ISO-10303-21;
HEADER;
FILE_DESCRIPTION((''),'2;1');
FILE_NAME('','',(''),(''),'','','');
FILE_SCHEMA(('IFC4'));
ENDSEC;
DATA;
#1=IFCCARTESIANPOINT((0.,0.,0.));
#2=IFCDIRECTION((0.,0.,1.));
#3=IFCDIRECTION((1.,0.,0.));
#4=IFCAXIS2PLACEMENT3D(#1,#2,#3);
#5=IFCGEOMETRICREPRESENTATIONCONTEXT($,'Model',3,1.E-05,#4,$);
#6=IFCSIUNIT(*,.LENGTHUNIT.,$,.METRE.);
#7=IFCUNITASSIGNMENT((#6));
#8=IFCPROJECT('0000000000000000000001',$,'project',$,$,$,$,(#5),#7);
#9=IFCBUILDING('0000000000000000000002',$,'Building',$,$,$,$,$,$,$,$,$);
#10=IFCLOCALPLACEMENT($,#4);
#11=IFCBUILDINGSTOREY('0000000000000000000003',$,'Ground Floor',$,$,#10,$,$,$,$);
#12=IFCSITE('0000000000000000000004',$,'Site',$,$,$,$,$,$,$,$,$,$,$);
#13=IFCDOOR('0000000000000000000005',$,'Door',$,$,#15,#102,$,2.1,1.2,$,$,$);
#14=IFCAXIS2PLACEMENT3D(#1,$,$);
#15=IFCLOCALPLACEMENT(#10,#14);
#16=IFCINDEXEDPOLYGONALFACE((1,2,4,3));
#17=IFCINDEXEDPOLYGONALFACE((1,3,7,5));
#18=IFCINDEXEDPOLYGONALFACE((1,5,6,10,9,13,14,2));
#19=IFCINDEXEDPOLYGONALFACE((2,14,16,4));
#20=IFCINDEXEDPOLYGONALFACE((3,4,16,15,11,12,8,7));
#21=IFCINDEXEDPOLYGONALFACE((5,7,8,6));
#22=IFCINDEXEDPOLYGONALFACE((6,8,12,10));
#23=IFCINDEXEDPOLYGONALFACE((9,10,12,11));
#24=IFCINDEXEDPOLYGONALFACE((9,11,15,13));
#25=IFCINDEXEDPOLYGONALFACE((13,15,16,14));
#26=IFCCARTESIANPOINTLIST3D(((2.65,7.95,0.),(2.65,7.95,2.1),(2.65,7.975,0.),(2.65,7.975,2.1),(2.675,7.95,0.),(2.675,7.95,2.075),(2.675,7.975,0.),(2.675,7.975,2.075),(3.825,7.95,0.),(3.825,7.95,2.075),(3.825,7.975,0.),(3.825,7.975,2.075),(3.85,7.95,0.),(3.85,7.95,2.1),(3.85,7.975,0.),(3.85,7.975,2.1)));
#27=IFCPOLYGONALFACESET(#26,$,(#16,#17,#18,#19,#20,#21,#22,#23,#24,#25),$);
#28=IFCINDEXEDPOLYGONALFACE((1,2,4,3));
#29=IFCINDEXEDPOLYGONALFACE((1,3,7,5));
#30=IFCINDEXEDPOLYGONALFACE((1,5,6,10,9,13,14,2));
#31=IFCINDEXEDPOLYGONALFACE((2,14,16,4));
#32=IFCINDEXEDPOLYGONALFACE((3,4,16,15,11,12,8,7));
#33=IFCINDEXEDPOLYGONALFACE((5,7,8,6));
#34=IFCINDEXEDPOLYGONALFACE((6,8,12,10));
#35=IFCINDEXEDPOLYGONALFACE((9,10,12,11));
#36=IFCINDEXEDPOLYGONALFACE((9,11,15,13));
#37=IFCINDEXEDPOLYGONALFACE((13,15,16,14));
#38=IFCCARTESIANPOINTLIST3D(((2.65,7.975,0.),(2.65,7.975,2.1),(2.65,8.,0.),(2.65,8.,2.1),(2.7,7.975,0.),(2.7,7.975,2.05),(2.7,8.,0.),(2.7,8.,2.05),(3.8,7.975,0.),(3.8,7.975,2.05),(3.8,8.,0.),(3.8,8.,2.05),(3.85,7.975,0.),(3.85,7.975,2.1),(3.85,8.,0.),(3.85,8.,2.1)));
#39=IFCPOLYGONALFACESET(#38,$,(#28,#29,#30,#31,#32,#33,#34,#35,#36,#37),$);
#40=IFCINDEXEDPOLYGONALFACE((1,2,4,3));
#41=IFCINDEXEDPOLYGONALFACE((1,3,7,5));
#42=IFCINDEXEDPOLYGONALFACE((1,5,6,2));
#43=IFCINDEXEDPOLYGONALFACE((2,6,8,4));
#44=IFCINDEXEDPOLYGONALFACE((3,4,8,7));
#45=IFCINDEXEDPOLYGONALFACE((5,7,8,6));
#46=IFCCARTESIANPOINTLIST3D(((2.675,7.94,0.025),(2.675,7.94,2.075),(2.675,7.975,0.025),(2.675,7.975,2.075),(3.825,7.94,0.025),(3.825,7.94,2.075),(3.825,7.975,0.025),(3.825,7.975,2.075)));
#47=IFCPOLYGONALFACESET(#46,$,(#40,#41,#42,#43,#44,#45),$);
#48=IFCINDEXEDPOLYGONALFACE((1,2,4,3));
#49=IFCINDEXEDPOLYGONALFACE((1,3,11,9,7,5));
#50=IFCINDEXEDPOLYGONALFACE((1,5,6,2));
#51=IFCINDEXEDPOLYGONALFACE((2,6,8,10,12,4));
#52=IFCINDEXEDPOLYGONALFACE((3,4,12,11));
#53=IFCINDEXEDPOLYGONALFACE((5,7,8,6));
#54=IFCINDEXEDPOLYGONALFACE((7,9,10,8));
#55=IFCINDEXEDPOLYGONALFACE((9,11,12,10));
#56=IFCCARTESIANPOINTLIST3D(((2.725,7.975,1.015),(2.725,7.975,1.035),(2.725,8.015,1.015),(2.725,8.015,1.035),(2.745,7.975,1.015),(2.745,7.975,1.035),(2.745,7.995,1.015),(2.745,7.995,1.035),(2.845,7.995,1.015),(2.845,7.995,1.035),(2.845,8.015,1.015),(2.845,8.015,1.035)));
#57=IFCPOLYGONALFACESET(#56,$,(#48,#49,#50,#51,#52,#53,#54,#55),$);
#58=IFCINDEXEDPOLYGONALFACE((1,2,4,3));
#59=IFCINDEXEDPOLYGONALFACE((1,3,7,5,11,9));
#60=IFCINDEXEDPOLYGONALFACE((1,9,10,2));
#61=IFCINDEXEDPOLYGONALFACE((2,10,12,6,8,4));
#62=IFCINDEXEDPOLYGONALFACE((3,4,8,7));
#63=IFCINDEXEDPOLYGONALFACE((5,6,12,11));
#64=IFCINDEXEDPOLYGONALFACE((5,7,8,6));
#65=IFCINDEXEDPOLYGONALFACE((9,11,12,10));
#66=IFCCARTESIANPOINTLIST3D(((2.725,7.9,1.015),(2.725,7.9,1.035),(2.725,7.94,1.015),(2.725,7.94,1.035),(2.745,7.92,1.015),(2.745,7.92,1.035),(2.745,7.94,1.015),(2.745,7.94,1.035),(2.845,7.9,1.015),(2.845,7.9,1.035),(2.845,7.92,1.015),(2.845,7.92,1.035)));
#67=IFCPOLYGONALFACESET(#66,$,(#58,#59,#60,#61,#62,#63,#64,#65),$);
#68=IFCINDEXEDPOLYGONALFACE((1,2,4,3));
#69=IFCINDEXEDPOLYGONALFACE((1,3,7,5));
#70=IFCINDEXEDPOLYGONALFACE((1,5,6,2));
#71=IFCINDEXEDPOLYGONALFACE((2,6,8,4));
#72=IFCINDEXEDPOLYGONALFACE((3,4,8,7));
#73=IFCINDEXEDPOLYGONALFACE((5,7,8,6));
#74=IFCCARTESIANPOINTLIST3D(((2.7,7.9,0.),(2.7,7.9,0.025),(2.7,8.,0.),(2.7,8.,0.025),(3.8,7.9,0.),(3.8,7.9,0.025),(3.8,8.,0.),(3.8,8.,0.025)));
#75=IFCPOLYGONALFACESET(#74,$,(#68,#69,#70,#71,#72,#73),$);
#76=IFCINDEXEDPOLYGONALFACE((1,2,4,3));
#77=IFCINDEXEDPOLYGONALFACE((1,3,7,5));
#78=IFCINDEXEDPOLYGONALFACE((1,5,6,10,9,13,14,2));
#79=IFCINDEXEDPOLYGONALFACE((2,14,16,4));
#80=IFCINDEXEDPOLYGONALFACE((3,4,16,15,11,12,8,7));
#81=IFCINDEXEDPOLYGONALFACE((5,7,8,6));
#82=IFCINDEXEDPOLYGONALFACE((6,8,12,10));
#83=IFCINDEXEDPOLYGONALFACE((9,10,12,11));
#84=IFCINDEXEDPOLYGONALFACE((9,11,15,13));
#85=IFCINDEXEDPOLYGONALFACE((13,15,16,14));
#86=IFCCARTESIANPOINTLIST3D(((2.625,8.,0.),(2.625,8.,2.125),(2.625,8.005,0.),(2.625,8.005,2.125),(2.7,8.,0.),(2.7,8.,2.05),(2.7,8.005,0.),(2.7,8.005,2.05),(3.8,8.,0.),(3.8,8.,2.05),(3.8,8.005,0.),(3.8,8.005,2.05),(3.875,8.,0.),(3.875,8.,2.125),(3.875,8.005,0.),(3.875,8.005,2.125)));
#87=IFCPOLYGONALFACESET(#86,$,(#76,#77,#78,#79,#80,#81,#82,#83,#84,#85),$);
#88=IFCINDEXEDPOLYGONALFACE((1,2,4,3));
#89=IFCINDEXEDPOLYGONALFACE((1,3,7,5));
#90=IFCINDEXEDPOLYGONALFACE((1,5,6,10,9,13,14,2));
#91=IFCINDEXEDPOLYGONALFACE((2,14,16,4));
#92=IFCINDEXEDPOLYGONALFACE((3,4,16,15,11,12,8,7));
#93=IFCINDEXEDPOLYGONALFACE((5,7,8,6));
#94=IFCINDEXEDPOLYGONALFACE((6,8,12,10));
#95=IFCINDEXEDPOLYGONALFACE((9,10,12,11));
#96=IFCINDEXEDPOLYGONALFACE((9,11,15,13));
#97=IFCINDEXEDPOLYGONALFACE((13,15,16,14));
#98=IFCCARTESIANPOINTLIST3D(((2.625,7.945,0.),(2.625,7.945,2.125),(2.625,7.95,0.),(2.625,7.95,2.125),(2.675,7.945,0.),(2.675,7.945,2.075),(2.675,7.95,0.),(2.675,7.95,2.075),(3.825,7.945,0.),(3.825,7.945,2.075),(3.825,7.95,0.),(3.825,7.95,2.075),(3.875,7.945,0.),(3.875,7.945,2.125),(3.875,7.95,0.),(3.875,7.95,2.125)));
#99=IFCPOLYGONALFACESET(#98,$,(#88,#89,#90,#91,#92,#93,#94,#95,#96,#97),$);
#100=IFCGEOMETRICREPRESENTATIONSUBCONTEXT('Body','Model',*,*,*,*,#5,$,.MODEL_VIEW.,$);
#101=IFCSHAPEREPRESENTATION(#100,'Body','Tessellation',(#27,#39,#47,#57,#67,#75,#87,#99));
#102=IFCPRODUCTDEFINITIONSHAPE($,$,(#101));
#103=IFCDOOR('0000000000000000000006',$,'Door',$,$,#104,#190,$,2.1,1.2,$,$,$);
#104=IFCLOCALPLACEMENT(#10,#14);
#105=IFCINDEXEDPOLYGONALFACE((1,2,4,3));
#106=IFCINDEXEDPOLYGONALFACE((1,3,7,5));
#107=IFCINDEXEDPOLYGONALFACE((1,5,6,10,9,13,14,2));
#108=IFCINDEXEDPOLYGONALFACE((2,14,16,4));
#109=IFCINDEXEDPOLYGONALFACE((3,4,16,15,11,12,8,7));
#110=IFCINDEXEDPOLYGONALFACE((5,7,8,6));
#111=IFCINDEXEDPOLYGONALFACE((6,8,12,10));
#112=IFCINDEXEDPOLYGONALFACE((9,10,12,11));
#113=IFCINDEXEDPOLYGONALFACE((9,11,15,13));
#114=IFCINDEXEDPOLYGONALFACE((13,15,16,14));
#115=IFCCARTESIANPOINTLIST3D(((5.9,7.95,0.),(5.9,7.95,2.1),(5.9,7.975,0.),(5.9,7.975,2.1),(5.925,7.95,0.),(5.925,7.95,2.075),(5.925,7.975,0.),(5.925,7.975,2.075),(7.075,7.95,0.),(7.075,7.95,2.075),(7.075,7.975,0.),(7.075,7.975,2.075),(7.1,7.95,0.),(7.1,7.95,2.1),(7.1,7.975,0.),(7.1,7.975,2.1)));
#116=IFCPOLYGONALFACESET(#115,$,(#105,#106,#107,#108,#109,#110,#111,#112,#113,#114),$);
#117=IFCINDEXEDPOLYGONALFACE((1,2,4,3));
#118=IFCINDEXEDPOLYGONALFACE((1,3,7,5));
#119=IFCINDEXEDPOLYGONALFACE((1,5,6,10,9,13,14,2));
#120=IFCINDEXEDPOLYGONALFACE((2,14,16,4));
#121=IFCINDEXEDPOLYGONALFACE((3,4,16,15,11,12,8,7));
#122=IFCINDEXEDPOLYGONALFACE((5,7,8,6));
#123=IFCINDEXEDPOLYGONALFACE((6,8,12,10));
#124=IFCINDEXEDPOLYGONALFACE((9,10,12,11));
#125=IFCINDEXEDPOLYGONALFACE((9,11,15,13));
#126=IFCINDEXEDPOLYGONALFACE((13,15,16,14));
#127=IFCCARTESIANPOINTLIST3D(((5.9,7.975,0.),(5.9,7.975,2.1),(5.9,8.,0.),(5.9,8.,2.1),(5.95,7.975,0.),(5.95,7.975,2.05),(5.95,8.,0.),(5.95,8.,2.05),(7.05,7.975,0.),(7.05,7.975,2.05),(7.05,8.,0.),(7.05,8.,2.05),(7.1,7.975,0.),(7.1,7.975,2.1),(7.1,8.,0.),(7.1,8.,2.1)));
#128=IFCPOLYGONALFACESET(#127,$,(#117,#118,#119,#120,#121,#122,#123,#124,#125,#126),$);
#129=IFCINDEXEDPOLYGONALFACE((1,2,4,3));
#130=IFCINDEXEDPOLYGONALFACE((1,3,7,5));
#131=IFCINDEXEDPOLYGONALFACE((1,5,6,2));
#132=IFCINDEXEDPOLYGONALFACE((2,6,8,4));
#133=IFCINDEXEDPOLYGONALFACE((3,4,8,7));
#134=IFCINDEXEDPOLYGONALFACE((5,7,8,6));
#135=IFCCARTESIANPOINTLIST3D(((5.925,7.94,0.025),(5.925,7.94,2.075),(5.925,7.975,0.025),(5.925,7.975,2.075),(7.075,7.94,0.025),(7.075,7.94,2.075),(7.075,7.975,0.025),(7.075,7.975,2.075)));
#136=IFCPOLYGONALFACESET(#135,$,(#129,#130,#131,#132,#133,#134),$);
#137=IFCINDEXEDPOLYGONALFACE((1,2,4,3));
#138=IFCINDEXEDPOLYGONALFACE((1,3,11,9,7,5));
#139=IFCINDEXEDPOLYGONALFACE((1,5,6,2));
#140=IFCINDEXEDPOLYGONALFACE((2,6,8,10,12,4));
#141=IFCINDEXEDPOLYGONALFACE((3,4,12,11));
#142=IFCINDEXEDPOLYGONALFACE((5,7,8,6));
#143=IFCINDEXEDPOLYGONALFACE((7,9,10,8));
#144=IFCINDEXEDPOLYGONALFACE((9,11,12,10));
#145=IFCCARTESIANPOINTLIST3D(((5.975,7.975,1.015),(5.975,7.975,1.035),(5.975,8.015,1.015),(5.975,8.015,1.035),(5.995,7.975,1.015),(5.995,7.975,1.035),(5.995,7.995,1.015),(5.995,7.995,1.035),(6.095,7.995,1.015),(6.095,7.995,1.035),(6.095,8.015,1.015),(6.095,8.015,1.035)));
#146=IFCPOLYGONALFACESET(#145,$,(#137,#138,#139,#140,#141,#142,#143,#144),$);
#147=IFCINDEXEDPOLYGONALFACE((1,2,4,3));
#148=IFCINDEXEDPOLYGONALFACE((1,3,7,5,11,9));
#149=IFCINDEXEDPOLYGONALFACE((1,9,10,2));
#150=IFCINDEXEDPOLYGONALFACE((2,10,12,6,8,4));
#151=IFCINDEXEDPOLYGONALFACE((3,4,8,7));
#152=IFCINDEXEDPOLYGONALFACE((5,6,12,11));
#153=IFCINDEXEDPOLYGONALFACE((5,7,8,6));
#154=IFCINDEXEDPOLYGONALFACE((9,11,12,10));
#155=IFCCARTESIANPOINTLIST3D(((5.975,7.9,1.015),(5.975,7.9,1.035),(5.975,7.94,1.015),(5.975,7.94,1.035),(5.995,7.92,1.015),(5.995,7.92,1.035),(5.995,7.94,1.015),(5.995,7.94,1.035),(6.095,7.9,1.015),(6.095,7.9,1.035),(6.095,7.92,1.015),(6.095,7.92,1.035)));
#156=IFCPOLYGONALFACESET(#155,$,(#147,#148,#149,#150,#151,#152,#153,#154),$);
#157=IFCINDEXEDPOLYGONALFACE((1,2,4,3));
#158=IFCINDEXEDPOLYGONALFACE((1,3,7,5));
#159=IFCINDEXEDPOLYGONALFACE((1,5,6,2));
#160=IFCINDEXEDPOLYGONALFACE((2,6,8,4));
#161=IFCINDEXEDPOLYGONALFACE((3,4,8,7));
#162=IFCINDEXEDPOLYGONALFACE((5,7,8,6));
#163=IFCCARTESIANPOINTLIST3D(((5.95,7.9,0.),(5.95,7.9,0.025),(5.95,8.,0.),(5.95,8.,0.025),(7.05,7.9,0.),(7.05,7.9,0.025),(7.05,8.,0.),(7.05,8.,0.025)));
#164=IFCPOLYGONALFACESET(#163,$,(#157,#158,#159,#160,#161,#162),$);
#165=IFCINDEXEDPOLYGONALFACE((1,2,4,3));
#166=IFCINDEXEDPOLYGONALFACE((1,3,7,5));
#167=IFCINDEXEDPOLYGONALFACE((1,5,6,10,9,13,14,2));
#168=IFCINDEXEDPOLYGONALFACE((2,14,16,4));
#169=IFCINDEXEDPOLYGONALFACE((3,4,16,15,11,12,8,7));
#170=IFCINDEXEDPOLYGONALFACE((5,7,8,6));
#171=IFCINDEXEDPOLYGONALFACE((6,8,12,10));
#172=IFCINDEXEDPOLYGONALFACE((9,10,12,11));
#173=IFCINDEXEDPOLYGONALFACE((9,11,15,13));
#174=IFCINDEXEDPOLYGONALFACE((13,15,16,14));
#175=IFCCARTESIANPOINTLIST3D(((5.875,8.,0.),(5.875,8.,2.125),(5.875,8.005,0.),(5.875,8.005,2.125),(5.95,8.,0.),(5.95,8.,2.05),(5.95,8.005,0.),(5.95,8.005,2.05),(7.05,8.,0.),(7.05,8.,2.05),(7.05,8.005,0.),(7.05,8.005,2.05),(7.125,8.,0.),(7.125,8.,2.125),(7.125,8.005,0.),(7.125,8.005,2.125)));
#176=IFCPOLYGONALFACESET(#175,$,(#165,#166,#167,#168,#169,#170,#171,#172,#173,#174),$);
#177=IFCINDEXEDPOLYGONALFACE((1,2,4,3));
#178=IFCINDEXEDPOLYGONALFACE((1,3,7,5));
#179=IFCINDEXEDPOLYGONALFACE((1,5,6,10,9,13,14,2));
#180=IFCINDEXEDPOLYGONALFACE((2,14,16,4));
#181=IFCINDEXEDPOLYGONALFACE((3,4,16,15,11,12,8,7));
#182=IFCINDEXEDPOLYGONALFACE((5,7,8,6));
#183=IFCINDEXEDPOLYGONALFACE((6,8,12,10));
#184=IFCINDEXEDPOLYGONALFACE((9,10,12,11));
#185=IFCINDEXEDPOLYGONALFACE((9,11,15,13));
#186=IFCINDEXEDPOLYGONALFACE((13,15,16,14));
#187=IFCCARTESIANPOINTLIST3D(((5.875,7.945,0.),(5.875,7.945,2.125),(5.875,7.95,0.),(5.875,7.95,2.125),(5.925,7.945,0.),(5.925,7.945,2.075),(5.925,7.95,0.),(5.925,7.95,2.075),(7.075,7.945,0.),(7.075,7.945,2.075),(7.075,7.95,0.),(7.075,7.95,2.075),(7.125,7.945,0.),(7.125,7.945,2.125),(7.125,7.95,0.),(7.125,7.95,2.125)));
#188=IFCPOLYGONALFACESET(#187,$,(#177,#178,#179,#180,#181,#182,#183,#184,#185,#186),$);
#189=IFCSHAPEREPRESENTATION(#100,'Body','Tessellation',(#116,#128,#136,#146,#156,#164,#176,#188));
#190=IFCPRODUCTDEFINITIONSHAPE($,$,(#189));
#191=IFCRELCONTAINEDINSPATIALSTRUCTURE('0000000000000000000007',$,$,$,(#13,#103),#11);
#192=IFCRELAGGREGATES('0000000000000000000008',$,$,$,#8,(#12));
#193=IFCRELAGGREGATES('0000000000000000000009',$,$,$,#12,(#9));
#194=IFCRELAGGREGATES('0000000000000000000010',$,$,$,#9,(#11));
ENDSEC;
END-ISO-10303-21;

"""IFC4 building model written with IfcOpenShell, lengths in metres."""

from ifc_helpers import new_model, si_unit, frame, origin_with_axes, place, context, subcontext, project, spatial, line, indexed_curve, outline, extrude, element, save


model = new_model("IFC4")

# Units and contexts
model_context = context("Model", 3, precision=1e-05, world=origin_with_axes())
body_context = subcontext(model_context, "Body", "Model", "MODEL_VIEW")
ifc_project = project(units=[si_unit("LENGTHUNIT", "METRE")], contexts=[model_context])

# Site, building, storey
site = spatial("IfcSite", under=ifc_project, Name="Site")
building = spatial("IfcBuilding", under=site, Name="Building")
storey_placement = place(None, origin_with_axes())
storey = spatial("IfcBuildingStorey", under=building, at=storey_placement, Name="Ground Floor")

# Doors
door_1_placement = place(storey_placement, frame((3.85, 8.0, 0.0), z_axis=(0.0, 0.0, 1.0), x_axis=(-1.0, 0.0, 0.0)))
element("IfcDoor", 1, at=door_1_placement, inside=storey, Name="Door", OverallHeight=2.1, OverallWidth=1.2, context=body_context, shape_type="SweptSolid", body=[
    extrude(outline(indexed_curve([(0.0, 0.0), (0.0, 2.1), (1.2, 2.1), (1.2, 0.0), (1.175, 0.0), (1.175, 2.075), (0.025, 2.075), (0.025, 0.0)], segments=[line(1, 2, 3, 4, 5, 6, 7, 8, 1)])), frame((0.0, 0.025, 0.0), z_axis=(0.0, -1.0, 0.0), x_axis=(1.0, 0.0, 0.0)), (0.0, 0.0, -1.0), 0.025),
    extrude(outline(indexed_curve([(0.0, 0.0), (0.0, 2.1), (1.2, 2.1), (1.2, 0.0), (1.15, 0.0), (1.15, 2.05), (0.05, 2.05), (0.05, 0.0)], segments=[line(1, 2, 3, 4, 5, 6, 7, 8, 1)])), frame((0.0, 0.0, 0.0), z_axis=(0.0, -1.0, 0.0), x_axis=(1.0, 0.0, 0.0)), (0.0, 0.0, -1.0), 0.025),
    extrude(outline(indexed_curve([(0.0, 0.0), (1.15, 0.0), (1.15, 0.035), (0.0, 0.035)], segments=[line(1, 2, 3, 4, 1)])), frame((0.025, 0.025, 0.025), z_axis=(0.0, 0.0, 1.0), x_axis=(1.0, 0.0, 0.0)), (0.0, 0.0, 1.0), 2.05),
    extrude(outline(indexed_curve([(0.0, 0.0), (0.0, -0.04), (-0.12, -0.04), (-0.12, -0.02), (-0.02, -0.02), (-0.02, 0.0)], segments=[line(1, 2, 3, 4, 5, 6, 1)])), frame((1.125, 0.025, 1.015), z_axis=(0.0, 0.0, 1.0), x_axis=(1.0, 0.0, 0.0)), (0.0, 0.0, 1.0), 0.02),
    extrude(outline(indexed_curve([(0.0, 0.0), (0.0, 0.04), (-0.12, 0.04), (-0.12, 0.02), (-0.02, 0.02), (-0.02, 0.0)], segments=[line(1, 2, 3, 4, 5, 6, 1)])), frame((1.125, 0.06, 1.015), z_axis=(0.0, 0.0, 1.0), x_axis=(1.0, 0.0, 0.0)), (0.0, 0.0, 1.0), 0.02),
    extrude(outline(indexed_curve([(0.0, 0.0), (1.1, 0.0), (1.1, 0.1), (0.0, 0.1)], segments=[line(1, 2, 3, 4, 1)])), frame((0.05, 0.0, 0.0), z_axis=(0.0, 0.0, 1.0), x_axis=(1.0, 0.0, 0.0)), (0.0, 0.0, 1.0), 0.025),
    extrude(outline(indexed_curve([(0.0, 0.0), (0.0, 2.125), (1.25, 2.125), (1.25, 0.0), (1.175, 0.0), (1.175, 2.05), (0.075, 2.05), (0.075, 0.0)], segments=[line(1, 2, 3, 4, 5, 6, 7, 8, 1)])), frame((-0.025, -0.005, 0.0), z_axis=(0.0, -1.0, 0.0), x_axis=(1.0, 0.0, 0.0)), (0.0, 0.0, -1.0), 0.005),
    extrude(outline(indexed_curve([(0.0, 0.0), (0.0, 2.125), (1.25, 2.125), (1.25, 0.0), (1.2, 0.0), (1.2, 2.075), (0.05, 2.075), (0.05, 0.0)], segments=[line(1, 2, 3, 4, 5, 6, 7, 8, 1)])), frame((-0.025, 0.05, 0.0), z_axis=(0.0, -1.0, 0.0), x_axis=(1.0, 0.0, 0.0)), (0.0, 0.0, -1.0), 0.005),
])
door_2_placement = place(storey_placement, frame((7.1, 8.0, 0.0), z_axis=(0.0, 0.0, 1.0), x_axis=(-1.0, 0.0, 0.0)))
element("IfcDoor", 2, at=door_2_placement, inside=storey, Name="Door", OverallHeight=2.1, OverallWidth=1.2, context=body_context, shape_type="SweptSolid", body=[
    extrude(outline(indexed_curve([(0.0, 0.0), (0.0, 2.1), (1.2, 2.1), (1.2, 0.0), (1.175, 0.0), (1.175, 2.075), (0.025, 2.075), (0.025, 0.0)], segments=[line(1, 2, 3, 4, 5, 6, 7, 8, 1)])), frame((0.0, 0.025, 0.0), z_axis=(0.0, -1.0, 0.0), x_axis=(1.0, 0.0, 0.0)), (0.0, 0.0, -1.0), 0.025),
    extrude(outline(indexed_curve([(0.0, 0.0), (0.0, 2.1), (1.2, 2.1), (1.2, 0.0), (1.15, 0.0), (1.15, 2.05), (0.05, 2.05), (0.05, 0.0)], segments=[line(1, 2, 3, 4, 5, 6, 7, 8, 1)])), frame((0.0, 0.0, 0.0), z_axis=(0.0, -1.0, 0.0), x_axis=(1.0, 0.0, 0.0)), (0.0, 0.0, -1.0), 0.025),
    extrude(outline(indexed_curve([(0.0, 0.0), (1.15, 0.0), (1.15, 0.035), (0.0, 0.035)], segments=[line(1, 2, 3, 4, 1)])), frame((0.025, 0.025, 0.025), z_axis=(0.0, 0.0, 1.0), x_axis=(1.0, 0.0, 0.0)), (0.0, 0.0, 1.0), 2.05),
    extrude(outline(indexed_curve([(0.0, 0.0), (0.0, -0.04), (-0.12, -0.04), (-0.12, -0.02), (-0.02, -0.02), (-0.02, 0.0)], segments=[line(1, 2, 3, 4, 5, 6, 1)])), frame((1.125, 0.025, 1.015), z_axis=(0.0, 0.0, 1.0), x_axis=(1.0, 0.0, 0.0)), (0.0, 0.0, 1.0), 0.02),
    extrude(outline(indexed_curve([(0.0, 0.0), (0.0, 0.04), (-0.12, 0.04), (-0.12, 0.02), (-0.02, 0.02), (-0.02, 0.0)], segments=[line(1, 2, 3, 4, 5, 6, 1)])), frame((1.125, 0.06, 1.015), z_axis=(0.0, 0.0, 1.0), x_axis=(1.0, 0.0, 0.0)), (0.0, 0.0, 1.0), 0.02),
    extrude(outline(indexed_curve([(0.0, 0.0), (1.1, 0.0), (1.1, 0.1), (0.0, 0.1)], segments=[line(1, 2, 3, 4, 1)])), frame((0.05, 0.0, 0.0), z_axis=(0.0, 0.0, 1.0), x_axis=(1.0, 0.0, 0.0)), (0.0, 0.0, 1.0), 0.025),
    extrude(outline(indexed_curve([(0.0, 0.0), (0.0, 2.125), (1.25, 2.125), (1.25, 0.0), (1.175, 0.0), (1.175, 2.05), (0.075, 2.05), (0.075, 0.0)], segments=[line(1, 2, 3, 4, 5, 6, 7, 8, 1)])), frame((-0.025, -0.005, 0.0), z_axis=(0.0, -1.0, 0.0), x_axis=(1.0, 0.0, 0.0)), (0.0, 0.0, -1.0), 0.005),
    extrude(outline(indexed_curve([(0.0, 0.0), (0.0, 2.125), (1.25, 2.125), (1.25, 0.0), (1.2, 0.0), (1.2, 2.075), (0.05, 2.075), (0.05, 0.0)], segments=[line(1, 2, 3, 4, 5, 6, 7, 8, 1)])), frame((-0.025, 0.05, 0.0), z_axis=(0.0, -1.0, 0.0), x_axis=(1.0, 0.0, 0.0)), (0.0, 0.0, -1.0), 0.005),
])

save(model, "model.ifc")
